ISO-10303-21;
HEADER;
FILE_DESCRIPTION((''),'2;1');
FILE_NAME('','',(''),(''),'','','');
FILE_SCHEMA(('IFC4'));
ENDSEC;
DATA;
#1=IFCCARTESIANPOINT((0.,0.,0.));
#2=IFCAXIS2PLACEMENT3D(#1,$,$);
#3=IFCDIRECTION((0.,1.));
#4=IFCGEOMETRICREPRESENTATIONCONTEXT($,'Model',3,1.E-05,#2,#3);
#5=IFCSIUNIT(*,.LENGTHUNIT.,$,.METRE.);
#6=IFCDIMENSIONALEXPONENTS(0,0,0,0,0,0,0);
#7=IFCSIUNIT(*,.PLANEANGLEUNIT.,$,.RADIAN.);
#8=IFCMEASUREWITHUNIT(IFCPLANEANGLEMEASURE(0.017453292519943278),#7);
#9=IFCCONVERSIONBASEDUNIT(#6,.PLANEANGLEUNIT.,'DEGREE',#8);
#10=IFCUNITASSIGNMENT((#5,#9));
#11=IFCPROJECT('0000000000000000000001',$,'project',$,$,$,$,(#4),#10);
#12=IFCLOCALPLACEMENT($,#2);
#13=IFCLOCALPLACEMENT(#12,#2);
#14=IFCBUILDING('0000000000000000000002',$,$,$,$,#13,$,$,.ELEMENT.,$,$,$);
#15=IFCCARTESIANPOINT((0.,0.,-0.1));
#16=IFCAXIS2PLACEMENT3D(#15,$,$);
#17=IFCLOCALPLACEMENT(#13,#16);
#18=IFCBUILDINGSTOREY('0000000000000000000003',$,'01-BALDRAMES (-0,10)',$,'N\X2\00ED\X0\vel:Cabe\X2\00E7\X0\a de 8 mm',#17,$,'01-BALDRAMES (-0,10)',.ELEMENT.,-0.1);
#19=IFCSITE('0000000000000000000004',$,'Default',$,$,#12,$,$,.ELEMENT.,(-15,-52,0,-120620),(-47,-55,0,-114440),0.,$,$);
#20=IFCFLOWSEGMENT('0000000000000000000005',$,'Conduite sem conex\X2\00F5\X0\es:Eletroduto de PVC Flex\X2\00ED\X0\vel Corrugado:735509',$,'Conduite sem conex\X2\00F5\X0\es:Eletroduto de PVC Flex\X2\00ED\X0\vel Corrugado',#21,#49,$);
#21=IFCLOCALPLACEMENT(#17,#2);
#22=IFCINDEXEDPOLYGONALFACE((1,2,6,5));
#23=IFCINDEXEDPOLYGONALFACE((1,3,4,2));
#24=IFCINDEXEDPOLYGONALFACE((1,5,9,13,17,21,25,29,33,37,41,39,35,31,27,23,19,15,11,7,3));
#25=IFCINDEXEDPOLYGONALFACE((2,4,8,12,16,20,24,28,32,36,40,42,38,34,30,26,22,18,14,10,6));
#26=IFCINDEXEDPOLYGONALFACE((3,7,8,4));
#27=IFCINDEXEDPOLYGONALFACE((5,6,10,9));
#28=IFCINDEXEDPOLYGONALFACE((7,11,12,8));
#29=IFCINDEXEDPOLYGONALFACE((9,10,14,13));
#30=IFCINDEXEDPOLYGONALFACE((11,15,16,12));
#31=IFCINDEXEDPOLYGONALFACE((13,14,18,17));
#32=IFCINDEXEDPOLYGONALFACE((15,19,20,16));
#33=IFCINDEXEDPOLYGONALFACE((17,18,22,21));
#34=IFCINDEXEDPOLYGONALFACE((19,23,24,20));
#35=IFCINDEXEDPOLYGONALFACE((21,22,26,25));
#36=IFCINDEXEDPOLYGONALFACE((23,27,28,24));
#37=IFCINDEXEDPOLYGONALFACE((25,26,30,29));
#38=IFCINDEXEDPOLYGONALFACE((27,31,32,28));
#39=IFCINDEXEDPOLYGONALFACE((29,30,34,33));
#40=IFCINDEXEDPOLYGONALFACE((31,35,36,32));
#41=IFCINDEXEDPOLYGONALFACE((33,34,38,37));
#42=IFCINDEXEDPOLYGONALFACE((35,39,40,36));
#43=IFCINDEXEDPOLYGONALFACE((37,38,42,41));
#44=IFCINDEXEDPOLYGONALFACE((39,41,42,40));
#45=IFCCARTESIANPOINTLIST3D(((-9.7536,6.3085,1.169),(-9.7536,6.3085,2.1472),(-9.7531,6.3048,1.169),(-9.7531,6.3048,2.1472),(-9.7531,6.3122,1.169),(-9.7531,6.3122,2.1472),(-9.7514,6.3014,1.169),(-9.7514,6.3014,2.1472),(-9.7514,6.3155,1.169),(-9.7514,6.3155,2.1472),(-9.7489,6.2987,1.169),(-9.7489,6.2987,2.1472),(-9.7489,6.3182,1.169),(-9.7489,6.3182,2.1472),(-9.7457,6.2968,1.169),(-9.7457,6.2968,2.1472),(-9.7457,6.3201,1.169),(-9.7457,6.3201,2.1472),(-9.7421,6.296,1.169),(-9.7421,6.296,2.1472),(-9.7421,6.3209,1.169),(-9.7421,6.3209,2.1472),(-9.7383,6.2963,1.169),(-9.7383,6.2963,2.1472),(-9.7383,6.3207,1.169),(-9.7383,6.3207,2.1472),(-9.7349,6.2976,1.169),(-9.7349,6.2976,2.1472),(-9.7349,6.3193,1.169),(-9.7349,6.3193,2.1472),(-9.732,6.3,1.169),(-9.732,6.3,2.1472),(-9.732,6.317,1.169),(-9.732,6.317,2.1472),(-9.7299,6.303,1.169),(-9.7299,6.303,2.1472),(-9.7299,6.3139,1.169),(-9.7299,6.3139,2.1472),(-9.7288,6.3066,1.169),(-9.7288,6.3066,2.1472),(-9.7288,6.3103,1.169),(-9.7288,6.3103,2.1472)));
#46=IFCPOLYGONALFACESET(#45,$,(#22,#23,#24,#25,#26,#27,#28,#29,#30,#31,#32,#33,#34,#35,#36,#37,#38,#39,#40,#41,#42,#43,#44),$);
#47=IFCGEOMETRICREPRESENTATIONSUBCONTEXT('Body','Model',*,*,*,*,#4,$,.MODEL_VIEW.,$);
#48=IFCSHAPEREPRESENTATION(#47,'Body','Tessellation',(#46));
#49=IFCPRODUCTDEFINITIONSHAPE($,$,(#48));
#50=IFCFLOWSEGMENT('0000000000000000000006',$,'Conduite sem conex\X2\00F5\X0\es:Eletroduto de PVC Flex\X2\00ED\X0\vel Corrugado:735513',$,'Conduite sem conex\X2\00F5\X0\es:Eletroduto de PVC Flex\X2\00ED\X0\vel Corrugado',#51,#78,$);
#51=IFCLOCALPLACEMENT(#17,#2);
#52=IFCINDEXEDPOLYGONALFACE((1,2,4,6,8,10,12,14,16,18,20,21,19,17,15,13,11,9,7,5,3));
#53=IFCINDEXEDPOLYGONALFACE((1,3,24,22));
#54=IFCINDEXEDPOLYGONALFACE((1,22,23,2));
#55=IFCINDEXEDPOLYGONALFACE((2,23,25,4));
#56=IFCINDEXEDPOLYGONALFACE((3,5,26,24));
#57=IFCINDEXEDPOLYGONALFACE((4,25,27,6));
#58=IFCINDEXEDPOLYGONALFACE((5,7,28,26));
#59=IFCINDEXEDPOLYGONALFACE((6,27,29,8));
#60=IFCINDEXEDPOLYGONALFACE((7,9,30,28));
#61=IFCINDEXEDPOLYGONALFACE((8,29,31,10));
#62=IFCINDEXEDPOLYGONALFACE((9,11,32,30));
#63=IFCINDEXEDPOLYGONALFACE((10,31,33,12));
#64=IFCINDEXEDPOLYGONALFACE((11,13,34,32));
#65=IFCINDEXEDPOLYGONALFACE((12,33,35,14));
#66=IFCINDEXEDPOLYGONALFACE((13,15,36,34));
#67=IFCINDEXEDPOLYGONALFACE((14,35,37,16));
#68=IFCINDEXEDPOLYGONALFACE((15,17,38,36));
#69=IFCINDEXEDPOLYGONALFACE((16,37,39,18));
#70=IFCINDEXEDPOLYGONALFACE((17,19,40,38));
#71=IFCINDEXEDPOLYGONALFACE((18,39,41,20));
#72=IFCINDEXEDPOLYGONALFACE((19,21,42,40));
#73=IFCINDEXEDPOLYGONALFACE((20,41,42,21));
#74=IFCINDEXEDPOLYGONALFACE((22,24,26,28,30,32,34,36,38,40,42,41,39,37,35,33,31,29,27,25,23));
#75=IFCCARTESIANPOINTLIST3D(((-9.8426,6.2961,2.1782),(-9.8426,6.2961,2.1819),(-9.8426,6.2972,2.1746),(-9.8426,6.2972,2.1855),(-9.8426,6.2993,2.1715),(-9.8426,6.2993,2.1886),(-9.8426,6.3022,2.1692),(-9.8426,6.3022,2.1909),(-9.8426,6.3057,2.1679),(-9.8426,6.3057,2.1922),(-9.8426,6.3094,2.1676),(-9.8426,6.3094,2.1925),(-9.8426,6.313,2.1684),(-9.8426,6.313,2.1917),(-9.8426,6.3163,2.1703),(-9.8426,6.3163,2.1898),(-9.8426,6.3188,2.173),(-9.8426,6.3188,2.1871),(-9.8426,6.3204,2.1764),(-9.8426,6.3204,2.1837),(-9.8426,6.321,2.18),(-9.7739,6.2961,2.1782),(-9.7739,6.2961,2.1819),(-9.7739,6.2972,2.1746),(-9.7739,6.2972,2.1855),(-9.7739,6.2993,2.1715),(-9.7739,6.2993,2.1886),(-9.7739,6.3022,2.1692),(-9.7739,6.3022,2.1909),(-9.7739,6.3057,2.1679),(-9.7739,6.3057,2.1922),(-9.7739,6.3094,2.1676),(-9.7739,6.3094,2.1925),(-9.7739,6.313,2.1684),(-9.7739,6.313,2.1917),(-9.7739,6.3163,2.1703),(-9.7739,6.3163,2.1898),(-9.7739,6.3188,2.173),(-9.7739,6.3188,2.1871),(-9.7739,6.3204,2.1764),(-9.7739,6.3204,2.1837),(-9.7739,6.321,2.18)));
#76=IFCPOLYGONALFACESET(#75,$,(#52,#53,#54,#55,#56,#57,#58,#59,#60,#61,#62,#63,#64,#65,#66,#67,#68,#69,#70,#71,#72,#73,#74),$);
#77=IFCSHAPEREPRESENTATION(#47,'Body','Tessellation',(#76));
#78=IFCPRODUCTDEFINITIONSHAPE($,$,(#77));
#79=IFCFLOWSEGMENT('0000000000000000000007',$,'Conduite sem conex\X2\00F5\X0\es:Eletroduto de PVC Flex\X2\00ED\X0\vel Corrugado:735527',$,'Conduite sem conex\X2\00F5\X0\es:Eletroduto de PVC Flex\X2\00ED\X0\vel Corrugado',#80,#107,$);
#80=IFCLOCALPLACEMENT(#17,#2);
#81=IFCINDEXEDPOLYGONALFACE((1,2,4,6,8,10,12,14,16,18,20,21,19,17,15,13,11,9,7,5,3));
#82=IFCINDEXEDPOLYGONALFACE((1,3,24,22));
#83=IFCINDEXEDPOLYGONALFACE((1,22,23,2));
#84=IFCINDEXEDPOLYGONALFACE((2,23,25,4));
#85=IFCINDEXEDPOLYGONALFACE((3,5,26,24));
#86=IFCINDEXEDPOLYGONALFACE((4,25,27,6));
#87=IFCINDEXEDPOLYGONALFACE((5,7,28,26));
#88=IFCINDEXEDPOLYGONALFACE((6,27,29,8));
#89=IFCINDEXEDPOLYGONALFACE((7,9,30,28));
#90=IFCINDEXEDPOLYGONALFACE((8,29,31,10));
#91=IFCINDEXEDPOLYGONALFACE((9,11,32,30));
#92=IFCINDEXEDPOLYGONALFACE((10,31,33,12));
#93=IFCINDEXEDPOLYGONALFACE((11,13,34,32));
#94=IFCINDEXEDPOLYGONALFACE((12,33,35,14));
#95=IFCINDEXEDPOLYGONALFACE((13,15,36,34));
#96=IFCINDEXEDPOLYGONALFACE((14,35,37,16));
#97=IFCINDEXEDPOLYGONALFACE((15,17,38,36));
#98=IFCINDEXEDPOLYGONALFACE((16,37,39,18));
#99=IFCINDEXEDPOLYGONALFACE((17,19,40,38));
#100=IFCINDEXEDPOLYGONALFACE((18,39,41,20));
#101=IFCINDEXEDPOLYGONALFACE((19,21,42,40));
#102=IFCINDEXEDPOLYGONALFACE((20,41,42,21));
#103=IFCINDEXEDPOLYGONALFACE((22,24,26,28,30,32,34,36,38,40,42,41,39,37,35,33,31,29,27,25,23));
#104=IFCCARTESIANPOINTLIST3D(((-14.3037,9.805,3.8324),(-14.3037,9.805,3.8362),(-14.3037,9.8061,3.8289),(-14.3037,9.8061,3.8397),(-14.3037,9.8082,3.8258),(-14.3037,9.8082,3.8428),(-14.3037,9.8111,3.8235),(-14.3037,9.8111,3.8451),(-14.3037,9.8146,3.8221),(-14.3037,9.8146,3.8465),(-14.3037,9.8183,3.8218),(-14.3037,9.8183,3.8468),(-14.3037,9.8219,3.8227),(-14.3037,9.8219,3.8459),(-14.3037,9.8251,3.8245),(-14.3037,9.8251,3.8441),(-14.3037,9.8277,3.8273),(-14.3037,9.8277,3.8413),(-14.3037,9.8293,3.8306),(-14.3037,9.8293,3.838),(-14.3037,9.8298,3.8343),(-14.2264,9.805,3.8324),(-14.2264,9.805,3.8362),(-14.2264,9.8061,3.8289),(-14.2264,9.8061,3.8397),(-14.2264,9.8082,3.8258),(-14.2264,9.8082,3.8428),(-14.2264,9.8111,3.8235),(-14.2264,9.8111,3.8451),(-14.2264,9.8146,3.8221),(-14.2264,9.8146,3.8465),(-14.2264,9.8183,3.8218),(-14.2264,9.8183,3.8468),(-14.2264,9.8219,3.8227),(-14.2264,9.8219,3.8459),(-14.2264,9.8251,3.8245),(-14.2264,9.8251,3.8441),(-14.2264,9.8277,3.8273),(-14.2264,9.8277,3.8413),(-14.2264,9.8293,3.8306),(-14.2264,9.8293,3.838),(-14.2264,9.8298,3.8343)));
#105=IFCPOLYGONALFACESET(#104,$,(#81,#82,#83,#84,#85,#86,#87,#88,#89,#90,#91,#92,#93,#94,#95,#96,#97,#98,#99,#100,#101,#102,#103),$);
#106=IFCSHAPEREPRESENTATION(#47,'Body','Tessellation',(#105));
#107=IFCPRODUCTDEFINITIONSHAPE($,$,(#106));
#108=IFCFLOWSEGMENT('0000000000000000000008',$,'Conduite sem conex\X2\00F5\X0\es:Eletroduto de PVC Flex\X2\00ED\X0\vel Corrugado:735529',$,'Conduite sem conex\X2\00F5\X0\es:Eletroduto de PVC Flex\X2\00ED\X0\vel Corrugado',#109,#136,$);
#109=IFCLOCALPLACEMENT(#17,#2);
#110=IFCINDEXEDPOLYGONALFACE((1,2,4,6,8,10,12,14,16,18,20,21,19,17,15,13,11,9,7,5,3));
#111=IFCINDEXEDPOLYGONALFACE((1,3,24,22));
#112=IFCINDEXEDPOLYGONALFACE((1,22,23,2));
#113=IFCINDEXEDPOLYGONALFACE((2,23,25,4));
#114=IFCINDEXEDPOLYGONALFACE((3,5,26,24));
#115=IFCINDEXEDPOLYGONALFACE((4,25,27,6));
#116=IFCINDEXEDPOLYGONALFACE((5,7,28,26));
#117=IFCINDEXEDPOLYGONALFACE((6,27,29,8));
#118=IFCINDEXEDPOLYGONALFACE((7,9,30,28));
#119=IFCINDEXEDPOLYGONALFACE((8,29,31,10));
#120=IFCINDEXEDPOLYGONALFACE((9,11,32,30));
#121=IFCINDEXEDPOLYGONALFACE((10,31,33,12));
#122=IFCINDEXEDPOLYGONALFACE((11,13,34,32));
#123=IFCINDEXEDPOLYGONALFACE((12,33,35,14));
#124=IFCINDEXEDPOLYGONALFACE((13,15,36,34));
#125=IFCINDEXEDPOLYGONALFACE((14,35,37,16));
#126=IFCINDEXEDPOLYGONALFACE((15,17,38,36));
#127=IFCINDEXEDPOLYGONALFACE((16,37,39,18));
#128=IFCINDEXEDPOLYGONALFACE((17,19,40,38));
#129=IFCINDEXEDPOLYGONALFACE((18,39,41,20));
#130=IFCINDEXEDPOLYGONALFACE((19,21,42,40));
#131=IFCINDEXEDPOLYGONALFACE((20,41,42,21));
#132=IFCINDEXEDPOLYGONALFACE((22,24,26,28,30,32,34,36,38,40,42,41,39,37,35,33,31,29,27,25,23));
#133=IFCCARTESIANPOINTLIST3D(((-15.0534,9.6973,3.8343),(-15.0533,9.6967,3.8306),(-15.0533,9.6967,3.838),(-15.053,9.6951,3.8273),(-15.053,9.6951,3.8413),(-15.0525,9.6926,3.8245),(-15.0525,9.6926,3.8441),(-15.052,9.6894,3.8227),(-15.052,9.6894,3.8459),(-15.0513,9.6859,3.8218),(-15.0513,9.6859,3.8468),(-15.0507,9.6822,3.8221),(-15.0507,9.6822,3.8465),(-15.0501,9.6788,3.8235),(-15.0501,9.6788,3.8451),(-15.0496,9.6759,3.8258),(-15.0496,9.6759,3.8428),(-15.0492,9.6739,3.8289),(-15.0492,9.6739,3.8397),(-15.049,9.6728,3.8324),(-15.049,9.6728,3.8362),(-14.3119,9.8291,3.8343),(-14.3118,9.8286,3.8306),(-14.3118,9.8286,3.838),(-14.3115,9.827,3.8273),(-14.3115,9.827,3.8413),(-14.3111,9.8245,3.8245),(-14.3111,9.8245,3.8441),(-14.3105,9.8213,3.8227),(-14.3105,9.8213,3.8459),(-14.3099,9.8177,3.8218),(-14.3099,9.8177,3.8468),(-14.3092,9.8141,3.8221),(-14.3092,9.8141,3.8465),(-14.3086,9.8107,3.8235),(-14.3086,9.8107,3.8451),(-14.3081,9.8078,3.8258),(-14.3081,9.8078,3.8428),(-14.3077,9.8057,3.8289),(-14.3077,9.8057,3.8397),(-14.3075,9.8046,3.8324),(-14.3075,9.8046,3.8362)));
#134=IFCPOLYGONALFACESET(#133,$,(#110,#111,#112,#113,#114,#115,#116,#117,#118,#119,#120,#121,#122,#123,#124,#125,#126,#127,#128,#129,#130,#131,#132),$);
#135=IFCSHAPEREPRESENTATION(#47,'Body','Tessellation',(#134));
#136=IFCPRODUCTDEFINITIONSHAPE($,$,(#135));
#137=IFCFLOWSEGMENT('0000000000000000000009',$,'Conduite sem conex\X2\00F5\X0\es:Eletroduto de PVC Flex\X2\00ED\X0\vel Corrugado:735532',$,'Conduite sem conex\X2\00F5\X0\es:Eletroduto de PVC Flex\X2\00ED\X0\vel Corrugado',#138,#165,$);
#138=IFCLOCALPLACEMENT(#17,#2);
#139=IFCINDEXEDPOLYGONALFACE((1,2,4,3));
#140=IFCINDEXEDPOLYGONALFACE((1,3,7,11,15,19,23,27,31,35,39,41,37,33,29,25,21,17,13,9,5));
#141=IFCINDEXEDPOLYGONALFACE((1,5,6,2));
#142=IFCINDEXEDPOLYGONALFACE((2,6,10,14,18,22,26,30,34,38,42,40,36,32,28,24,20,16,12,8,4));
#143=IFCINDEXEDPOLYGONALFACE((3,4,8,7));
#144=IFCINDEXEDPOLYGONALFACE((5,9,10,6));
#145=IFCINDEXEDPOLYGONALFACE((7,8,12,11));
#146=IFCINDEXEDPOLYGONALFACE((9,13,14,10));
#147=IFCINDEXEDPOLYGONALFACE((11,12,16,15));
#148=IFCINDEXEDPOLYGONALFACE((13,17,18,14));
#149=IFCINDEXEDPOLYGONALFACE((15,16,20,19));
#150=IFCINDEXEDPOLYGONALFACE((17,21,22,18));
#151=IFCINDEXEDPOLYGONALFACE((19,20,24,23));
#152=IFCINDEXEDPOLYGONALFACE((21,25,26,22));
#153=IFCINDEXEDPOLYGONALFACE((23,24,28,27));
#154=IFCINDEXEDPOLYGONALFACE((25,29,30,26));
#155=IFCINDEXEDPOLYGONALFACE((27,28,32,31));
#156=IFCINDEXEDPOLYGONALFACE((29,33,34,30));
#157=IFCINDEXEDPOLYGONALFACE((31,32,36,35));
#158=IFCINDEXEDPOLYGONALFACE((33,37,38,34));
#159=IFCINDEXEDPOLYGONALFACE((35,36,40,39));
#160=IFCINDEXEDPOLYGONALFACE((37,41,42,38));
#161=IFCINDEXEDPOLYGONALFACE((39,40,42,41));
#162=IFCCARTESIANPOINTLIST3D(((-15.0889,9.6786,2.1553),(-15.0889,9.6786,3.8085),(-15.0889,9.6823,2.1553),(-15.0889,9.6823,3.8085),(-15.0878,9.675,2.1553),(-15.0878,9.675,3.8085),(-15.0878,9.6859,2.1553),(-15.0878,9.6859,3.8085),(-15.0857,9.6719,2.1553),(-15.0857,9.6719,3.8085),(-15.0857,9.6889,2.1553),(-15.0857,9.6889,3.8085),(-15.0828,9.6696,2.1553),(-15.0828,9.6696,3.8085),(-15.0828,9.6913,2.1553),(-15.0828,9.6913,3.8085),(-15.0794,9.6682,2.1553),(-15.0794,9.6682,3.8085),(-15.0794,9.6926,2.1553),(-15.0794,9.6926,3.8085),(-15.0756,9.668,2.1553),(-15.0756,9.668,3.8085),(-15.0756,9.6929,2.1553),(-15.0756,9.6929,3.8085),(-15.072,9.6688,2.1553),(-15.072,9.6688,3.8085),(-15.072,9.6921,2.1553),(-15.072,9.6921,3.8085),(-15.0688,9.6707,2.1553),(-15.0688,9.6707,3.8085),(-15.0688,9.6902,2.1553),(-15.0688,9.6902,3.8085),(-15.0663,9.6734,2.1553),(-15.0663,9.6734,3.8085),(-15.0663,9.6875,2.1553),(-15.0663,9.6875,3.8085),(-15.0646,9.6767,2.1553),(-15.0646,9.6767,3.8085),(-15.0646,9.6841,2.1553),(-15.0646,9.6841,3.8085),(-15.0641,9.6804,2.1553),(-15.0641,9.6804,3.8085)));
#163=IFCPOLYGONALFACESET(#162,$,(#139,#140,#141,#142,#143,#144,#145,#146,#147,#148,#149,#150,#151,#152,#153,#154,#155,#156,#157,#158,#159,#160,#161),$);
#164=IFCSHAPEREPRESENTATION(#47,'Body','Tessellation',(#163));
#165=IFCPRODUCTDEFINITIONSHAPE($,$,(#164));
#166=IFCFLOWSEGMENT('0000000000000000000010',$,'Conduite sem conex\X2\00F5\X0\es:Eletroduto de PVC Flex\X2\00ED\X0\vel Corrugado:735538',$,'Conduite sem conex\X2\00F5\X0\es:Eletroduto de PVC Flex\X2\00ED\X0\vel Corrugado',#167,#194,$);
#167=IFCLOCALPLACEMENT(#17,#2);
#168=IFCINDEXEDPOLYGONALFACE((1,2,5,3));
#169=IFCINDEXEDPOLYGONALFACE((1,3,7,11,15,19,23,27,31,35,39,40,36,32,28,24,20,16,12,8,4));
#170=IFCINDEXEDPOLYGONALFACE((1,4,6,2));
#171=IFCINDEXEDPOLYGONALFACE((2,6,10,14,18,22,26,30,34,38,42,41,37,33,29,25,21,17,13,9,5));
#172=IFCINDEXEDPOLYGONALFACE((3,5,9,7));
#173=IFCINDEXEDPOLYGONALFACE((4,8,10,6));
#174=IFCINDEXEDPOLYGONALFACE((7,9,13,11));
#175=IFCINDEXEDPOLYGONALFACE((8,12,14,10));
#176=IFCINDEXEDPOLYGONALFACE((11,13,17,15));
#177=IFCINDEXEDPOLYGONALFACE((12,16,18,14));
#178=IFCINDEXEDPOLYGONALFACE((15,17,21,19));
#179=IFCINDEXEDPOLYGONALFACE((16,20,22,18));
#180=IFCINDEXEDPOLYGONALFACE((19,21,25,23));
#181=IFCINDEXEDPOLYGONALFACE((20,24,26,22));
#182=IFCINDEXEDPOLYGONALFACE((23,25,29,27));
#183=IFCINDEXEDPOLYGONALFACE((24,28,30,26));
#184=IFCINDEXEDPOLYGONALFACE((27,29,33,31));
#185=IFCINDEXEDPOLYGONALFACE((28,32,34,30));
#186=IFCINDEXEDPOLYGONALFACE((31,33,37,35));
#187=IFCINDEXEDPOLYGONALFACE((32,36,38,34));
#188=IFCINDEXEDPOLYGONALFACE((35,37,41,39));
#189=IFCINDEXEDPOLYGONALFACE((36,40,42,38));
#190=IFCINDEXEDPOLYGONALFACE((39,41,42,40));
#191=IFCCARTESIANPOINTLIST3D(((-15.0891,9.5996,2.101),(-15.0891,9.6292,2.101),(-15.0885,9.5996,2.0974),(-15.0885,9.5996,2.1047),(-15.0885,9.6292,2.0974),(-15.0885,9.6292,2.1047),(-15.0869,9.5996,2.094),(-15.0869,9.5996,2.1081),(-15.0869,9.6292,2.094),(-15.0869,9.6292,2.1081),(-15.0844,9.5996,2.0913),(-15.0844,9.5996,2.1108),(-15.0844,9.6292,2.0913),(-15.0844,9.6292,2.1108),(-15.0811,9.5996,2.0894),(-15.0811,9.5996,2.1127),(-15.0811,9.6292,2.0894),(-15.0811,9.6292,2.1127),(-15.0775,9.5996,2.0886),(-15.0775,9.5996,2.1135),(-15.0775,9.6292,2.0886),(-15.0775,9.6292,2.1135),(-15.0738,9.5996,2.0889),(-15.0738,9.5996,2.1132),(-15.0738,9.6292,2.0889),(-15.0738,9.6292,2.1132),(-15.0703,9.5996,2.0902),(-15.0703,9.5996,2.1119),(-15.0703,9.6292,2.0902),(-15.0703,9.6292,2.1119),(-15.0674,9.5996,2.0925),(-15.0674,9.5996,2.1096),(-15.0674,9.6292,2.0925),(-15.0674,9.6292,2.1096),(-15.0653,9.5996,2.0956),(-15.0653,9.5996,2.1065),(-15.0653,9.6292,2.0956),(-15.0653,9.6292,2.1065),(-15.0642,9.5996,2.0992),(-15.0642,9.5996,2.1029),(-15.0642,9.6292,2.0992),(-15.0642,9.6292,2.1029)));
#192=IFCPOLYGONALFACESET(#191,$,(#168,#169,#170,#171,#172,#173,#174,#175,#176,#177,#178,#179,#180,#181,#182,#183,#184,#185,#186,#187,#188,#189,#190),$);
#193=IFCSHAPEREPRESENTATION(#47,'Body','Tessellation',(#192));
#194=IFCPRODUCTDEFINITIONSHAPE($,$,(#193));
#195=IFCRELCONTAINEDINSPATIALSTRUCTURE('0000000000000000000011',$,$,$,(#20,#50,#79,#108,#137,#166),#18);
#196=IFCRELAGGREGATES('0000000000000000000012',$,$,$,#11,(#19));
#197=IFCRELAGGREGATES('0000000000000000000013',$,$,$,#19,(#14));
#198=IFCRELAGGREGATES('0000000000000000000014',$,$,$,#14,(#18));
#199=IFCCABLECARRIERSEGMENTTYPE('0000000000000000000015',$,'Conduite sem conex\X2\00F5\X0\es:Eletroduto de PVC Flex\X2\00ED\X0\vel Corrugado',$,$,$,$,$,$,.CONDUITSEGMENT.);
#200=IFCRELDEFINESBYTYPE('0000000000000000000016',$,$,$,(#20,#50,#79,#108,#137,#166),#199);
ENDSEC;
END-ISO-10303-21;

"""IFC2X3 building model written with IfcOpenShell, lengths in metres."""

from ifc_helpers import new_model, entity, si_unit, converted_unit, direction, frame, frame_2d, origin, origin_2d_with_axis, place, context, subcontext, project, spatial, circle, extrude, type_object, element, save


model = new_model("IFC2X3")

# Units and contexts
model_context = context("Model", 3, precision=1e-05, world=origin(), true_north=direction((0.0, 1.0)))
body_context = subcontext(model_context, "Body", "Model", "MODEL_VIEW")
ifc_project = project(units=[si_unit("LENGTHUNIT", "METRE"), converted_unit("PLANEANGLEUNIT", "DEGREE", entity("IfcPlaneAngleMeasure", 0.017453292519943278), si_unit("PLANEANGLEUNIT", "RADIAN"), dimensions=[0, 0, 0, 0, 0, 0, 0])], contexts=[model_context])

# Site, building, storey
site_placement = place(None, origin())
site = spatial("IfcSite", under=ifc_project, at=site_placement, Name="Default", CompositionType="ELEMENT", RefLatitude=(-15, -52, 0, -120620), RefLongitude=(-47, -55, 0, -114440), RefElevation=0.0)
building_placement = place(site_placement, origin())
building = spatial("IfcBuilding", under=site, at=building_placement, CompositionType="ELEMENT")
storey_placement = place(building_placement, frame((0.0, 0.0, -0.1)))
storey = spatial("IfcBuildingStorey", under=building, at=storey_placement, Name="01-BALDRAMES (-0,10)", ObjectType="Nível:Cabeça de 8 mm", LongName="01-BALDRAMES (-0,10)", CompositionType="ELEMENT", Elevation=-0.1)

# Flow segments
cable_carrier_segment_type = type_object("IfcCableCarrierSegmentType", Name="Conduite sem conexões:Eletroduto de PVC Flexível Corrugado", PredefinedType="CONDUITSEGMENT")
flow_segment_1_placement = place(storey_placement, origin())
element("IfcFlowSegment", 1, at=flow_segment_1_placement, inside=storey, type_object=cable_carrier_segment_type, Name="Conduite sem conexões:Eletroduto de PVC Flexível Corrugado:735509", ObjectType="Conduite sem conexões:Eletroduto de PVC Flexível Corrugado", context=body_context, shape_type="SweptSolid", body=[
    extrude(circle(Radius=0.0125, at=frame_2d((0.0, 0.0), x_axis=(1.0, 0.0))), frame((-9.7411, 6.3085, 1.169), z_axis=(0.0, 0.0, 1.0), x_axis=(-1.0, 0.0, 0.0)), (0.0, 0.0, 1.0), 0.9783),
])
flow_segment_2_placement = place(storey_placement, origin())
element("IfcFlowSegment", 2, at=flow_segment_2_placement, inside=storey, type_object=cable_carrier_segment_type, Name="Conduite sem conexões:Eletroduto de PVC Flexível Corrugado:735513", ObjectType="Conduite sem conexões:Eletroduto de PVC Flexível Corrugado", context=body_context, shape_type="SweptSolid", body=[
    extrude(circle(Radius=0.0125, at=origin_2d_with_axis()), frame((-9.8426, 6.3085, 2.18), z_axis=(1.0, 0.0, 0.0), x_axis=(0.0, 1.0, 0.0)), (0.0, 0.0, 1.0), 0.0687),
])
flow_segment_3_placement = place(storey_placement, origin())
element("IfcFlowSegment", 3, at=flow_segment_3_placement, inside=storey, type_object=cable_carrier_segment_type, Name="Conduite sem conexões:Eletroduto de PVC Flexível Corrugado:735527", ObjectType="Conduite sem conexões:Eletroduto de PVC Flexível Corrugado", context=body_context, shape_type="SweptSolid", body=[
    extrude(circle(Radius=0.0125, at=origin_2d_with_axis()), frame((-14.3037, 9.8173, 3.8343), z_axis=(1.0, 0.0, 0.0), x_axis=(0.0, 1.0, 0.0)), (0.0, 0.0, 1.0), 0.0774),
])
flow_segment_4_placement = place(storey_placement, origin())
element("IfcFlowSegment", 4, at=flow_segment_4_placement, inside=storey, type_object=cable_carrier_segment_type, Name="Conduite sem conexões:Eletroduto de PVC Flexível Corrugado:735529", ObjectType="Conduite sem conexões:Eletroduto de PVC Flexível Corrugado", context=body_context, shape_type="SweptSolid", body=[
    extrude(circle(Radius=0.0125, at=origin_2d_with_axis()), frame((-15.0512, 9.6849, 3.8343), z_axis=(0.98455, 0.175102, 0.0), x_axis=(-0.175102, 0.98455, 0.0)), (0.0, 0.0, 1.0), 0.7531),
])
flow_segment_5_placement = place(storey_placement, origin())
element("IfcFlowSegment", 5, at=flow_segment_5_placement, inside=storey, type_object=cable_carrier_segment_type, Name="Conduite sem conexões:Eletroduto de PVC Flexível Corrugado:735532", ObjectType="Conduite sem conexões:Eletroduto de PVC Flexível Corrugado", context=body_context, shape_type="SweptSolid", body=[
    extrude(circle(Radius=0.0125, at=origin_2d_with_axis()), frame((-15.0766, 9.6804, 2.1553)), (0.0, 0.0, 1.0), 1.6532),
])
flow_segment_6_placement = place(storey_placement, origin())
element("IfcFlowSegment", 6, at=flow_segment_6_placement, inside=storey, type_object=cable_carrier_segment_type, Name="Conduite sem conexões:Eletroduto de PVC Flexível Corrugado:735538", ObjectType="Conduite sem conexões:Eletroduto de PVC Flexível Corrugado", context=body_context, shape_type="SweptSolid", body=[
    extrude(circle(Radius=0.0125, at=frame_2d((0.0, 0.0), x_axis=(1.0, 0.0))), frame((-15.0766, 9.6292, 2.101), z_axis=(0.000011, -1.0, 0.0), x_axis=(-1.0, -0.000011, 0.0)), (0.0, 0.0, 1.0), 0.0296),
])

save(model, "model.ifc")
